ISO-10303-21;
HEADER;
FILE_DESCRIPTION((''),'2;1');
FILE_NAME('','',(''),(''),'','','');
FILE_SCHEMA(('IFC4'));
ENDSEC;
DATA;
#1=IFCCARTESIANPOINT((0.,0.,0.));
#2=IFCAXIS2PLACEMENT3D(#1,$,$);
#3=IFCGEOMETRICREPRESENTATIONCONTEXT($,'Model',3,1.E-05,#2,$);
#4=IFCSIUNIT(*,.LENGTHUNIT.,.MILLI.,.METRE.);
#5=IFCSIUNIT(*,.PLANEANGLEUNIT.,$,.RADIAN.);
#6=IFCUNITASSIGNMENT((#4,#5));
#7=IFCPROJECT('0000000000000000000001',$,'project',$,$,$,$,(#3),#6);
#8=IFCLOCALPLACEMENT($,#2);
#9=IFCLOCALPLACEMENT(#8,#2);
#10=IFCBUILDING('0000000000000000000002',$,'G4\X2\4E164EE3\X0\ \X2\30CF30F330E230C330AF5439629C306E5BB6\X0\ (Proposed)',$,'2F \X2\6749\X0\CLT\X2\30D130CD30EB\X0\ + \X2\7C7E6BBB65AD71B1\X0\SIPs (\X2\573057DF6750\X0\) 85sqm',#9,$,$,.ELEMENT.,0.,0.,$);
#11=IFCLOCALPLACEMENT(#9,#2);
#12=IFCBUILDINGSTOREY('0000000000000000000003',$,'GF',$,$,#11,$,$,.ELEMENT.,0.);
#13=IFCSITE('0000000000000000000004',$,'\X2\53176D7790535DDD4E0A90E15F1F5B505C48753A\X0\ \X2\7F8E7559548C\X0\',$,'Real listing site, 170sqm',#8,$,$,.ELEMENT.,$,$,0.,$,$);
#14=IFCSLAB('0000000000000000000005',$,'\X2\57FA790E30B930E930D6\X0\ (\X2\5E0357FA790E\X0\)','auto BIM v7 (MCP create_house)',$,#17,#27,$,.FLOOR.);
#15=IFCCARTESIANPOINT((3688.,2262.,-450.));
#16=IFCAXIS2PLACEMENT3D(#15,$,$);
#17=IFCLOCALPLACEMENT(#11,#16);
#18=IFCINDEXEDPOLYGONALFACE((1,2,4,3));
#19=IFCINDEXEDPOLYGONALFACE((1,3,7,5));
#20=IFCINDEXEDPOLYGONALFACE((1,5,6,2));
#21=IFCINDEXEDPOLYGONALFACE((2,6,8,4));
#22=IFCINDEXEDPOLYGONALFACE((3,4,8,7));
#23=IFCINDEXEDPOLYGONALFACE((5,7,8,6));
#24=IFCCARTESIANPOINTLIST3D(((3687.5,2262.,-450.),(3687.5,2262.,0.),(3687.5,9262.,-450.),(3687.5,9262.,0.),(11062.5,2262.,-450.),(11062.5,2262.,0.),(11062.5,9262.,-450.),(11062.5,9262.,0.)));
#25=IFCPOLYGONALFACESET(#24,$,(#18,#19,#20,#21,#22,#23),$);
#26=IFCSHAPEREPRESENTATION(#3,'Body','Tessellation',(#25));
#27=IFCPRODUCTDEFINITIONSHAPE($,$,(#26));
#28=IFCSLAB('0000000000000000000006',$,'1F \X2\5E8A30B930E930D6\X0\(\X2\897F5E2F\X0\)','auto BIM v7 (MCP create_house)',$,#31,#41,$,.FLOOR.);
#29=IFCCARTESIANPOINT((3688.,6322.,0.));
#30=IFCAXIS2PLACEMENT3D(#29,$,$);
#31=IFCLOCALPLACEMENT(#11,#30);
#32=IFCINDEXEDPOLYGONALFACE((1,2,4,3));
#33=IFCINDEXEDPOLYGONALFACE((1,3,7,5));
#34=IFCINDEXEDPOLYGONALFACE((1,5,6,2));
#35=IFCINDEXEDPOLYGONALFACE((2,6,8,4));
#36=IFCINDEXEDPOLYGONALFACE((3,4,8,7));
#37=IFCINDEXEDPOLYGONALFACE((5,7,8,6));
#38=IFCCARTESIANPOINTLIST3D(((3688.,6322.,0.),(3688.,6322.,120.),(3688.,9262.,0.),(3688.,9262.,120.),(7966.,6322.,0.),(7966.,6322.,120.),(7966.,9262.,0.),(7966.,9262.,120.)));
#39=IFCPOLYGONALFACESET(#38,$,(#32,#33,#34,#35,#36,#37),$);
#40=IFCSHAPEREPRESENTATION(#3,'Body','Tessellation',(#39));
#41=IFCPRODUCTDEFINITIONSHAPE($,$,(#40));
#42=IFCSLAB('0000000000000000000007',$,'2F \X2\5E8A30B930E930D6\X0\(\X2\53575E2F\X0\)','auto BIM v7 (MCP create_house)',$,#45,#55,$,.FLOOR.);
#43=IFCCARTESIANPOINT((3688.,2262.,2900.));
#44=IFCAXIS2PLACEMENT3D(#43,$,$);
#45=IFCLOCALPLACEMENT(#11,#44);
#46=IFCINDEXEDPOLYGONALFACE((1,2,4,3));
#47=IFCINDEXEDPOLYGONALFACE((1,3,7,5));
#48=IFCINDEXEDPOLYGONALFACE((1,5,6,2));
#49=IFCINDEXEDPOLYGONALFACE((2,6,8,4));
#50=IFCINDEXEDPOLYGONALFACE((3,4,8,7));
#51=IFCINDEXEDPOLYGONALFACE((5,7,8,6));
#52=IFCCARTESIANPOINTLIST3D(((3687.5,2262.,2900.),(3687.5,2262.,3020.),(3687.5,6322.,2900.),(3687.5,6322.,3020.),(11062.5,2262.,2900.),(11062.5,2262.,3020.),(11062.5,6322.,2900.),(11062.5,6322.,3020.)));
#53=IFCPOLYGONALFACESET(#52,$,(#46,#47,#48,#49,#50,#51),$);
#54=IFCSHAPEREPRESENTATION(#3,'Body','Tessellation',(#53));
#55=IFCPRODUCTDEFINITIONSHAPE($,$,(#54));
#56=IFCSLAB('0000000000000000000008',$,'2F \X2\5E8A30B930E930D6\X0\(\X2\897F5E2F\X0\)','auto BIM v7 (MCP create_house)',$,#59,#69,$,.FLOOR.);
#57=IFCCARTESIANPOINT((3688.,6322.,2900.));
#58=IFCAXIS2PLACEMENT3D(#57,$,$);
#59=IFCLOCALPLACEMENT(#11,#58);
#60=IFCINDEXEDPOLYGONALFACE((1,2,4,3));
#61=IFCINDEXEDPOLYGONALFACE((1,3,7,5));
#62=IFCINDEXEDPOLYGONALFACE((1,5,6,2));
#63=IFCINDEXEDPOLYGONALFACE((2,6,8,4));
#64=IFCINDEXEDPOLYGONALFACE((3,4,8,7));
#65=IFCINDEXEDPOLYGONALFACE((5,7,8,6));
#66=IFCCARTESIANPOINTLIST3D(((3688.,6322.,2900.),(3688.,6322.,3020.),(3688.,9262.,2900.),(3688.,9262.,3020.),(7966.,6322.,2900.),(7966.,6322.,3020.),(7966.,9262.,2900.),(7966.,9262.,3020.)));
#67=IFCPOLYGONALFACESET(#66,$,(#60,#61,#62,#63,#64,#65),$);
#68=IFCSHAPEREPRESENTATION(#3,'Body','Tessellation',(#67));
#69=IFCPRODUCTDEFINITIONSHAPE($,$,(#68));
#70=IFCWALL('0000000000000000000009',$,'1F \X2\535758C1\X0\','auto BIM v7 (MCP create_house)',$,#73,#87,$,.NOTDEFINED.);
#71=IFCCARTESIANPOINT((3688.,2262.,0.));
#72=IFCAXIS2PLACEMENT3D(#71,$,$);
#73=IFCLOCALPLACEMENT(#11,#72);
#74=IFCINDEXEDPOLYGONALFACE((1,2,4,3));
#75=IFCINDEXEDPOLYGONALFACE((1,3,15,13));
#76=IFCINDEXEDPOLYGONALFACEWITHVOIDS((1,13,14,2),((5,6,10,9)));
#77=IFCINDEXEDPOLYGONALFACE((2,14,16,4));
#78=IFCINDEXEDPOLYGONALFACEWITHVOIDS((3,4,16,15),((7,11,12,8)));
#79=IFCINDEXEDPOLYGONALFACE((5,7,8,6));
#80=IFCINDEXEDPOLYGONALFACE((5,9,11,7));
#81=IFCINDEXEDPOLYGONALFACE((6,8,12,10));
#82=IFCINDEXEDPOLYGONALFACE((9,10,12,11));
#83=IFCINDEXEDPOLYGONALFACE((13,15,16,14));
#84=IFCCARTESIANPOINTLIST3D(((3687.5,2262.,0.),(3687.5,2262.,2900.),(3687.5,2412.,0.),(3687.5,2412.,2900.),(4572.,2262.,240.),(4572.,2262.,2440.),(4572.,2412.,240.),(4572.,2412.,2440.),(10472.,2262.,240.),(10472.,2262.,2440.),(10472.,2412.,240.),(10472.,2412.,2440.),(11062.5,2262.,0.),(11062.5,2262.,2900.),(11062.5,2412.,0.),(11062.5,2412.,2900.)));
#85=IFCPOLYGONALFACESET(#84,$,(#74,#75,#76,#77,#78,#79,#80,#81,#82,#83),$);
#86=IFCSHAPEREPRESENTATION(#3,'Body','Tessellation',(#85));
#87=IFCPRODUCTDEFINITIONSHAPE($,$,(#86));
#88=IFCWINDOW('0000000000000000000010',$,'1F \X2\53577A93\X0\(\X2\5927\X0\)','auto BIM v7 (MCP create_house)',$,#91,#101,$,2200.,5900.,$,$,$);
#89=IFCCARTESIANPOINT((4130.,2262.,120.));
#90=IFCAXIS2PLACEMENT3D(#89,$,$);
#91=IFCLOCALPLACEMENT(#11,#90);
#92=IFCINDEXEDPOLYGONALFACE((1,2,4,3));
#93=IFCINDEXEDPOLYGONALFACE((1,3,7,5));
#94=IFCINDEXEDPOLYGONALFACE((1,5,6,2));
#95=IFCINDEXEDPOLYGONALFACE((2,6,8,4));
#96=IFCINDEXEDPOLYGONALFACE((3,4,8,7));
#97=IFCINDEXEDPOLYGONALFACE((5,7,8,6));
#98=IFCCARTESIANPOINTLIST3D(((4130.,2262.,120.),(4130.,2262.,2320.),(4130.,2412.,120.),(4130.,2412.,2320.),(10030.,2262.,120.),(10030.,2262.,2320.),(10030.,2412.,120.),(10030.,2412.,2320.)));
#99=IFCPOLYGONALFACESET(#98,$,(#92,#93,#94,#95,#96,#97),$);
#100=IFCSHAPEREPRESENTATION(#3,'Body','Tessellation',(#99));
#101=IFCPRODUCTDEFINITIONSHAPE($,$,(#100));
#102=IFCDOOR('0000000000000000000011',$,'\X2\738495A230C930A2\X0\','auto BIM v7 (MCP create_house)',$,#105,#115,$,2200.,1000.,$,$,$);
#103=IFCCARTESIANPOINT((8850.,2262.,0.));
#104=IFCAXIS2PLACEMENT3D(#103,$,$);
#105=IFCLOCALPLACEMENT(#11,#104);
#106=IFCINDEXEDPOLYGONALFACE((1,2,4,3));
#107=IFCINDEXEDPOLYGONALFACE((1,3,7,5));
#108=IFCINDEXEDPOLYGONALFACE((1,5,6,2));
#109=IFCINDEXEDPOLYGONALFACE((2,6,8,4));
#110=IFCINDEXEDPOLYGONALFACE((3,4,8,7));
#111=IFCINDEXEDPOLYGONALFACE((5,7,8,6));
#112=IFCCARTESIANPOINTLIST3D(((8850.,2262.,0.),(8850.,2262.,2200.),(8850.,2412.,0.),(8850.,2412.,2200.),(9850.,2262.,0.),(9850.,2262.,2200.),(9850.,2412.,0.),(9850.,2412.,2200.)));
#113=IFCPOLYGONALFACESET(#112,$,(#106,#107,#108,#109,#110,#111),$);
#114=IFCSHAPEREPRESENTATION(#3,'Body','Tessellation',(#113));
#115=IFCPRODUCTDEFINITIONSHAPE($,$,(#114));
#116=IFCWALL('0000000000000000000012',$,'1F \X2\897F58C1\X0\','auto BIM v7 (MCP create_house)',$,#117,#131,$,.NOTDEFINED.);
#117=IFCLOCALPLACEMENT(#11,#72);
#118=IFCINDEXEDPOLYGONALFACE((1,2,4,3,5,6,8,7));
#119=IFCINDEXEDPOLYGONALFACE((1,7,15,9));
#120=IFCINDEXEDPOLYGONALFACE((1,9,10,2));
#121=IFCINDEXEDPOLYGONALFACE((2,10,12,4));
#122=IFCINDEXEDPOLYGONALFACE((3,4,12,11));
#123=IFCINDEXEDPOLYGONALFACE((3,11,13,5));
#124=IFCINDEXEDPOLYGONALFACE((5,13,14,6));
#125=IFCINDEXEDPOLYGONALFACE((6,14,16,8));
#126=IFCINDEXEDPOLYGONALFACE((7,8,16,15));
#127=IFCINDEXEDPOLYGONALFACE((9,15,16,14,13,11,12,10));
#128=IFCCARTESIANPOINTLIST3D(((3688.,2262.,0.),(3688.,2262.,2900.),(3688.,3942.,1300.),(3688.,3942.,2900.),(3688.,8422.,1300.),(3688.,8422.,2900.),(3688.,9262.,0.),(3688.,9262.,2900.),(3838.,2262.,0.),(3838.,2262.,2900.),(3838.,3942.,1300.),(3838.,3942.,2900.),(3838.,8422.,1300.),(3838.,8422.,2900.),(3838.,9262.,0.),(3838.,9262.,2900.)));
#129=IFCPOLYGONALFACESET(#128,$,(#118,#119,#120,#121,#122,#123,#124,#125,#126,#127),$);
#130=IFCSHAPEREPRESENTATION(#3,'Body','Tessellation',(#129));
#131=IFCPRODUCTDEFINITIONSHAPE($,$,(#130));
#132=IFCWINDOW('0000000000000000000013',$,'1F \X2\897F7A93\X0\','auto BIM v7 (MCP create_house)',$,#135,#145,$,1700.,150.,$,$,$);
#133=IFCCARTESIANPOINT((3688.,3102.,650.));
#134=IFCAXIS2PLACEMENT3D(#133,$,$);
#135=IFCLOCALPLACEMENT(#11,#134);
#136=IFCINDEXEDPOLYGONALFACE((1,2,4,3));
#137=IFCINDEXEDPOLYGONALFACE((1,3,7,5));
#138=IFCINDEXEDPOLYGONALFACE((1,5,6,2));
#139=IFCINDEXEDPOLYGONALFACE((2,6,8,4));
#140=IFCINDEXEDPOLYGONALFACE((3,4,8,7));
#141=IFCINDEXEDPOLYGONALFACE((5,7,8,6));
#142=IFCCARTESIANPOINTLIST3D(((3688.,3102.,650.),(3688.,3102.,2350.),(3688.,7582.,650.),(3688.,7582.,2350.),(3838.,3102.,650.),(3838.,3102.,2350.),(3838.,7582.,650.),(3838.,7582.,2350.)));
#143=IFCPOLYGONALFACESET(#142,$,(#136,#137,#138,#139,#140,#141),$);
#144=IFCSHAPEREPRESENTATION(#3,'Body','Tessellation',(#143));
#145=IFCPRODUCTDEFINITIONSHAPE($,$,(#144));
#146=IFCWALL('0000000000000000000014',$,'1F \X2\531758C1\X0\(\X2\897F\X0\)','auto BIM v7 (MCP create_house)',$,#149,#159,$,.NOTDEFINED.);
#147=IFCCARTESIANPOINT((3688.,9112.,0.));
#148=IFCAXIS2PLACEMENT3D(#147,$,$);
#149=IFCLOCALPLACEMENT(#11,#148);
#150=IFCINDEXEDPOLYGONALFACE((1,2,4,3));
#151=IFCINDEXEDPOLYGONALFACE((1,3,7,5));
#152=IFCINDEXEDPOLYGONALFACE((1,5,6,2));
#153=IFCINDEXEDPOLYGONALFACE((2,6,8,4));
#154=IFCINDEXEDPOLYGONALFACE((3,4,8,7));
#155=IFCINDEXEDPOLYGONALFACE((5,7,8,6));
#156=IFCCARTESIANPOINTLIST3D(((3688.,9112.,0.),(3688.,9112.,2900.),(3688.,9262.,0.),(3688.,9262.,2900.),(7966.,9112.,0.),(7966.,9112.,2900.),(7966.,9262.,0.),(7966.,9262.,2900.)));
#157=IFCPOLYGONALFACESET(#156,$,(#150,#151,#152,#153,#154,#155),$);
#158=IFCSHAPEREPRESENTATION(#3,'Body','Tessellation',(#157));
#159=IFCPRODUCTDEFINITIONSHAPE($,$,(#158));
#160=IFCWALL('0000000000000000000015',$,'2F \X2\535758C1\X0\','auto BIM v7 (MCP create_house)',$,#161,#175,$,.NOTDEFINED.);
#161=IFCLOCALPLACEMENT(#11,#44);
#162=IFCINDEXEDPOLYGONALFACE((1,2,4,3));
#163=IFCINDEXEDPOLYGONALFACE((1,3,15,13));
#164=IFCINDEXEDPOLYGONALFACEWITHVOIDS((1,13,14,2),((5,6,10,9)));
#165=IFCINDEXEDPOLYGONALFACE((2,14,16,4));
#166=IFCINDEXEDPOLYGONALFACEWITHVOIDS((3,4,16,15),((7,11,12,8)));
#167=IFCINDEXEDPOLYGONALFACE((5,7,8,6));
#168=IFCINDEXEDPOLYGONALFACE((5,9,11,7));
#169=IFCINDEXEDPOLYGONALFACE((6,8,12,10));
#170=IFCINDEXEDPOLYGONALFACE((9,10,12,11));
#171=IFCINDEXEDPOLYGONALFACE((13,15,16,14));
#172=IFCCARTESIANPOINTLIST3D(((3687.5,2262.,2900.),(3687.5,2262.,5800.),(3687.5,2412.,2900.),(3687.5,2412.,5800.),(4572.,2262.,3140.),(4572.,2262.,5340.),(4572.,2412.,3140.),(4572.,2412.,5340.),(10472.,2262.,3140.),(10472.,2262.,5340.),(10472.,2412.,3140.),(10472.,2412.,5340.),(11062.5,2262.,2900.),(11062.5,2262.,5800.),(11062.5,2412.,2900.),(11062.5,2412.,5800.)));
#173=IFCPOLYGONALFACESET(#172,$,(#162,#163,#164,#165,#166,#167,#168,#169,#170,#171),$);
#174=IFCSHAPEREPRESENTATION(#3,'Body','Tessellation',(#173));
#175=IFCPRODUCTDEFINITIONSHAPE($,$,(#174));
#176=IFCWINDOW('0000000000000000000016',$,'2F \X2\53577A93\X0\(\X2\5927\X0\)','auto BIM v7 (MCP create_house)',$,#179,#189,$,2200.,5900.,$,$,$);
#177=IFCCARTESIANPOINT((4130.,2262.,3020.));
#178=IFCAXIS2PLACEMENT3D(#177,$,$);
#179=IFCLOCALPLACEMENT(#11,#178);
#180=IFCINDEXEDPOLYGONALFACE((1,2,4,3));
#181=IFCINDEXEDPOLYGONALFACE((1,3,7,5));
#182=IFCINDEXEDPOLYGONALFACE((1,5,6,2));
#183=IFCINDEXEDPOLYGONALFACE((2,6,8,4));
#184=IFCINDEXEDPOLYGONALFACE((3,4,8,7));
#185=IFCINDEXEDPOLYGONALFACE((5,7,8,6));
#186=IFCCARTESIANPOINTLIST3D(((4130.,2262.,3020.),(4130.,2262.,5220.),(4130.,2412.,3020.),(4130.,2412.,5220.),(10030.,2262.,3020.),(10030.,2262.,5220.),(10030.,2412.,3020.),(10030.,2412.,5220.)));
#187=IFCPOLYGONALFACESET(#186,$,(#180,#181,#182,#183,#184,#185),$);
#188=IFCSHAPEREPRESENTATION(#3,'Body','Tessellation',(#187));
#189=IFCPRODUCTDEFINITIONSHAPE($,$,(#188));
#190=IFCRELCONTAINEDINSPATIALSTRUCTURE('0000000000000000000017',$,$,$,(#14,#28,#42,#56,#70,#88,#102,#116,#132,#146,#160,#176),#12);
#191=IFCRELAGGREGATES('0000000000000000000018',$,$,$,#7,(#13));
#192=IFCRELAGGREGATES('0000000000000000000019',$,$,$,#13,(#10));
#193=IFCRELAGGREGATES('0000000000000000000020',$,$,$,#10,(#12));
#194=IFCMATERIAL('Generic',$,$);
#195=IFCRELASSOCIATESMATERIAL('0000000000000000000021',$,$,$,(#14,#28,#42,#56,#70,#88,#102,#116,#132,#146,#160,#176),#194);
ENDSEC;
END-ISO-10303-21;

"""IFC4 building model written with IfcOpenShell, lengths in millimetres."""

from ifc_helpers import new_model, si_unit, frame, frame_2d, origin, place, context, project, spatial, rectangle, extrude, material, element, fill, save


model = new_model("IFC4")

# Units and contexts
model_context = context("Model", 3, precision=1e-05, world=origin())
ifc_project = project(units=[si_unit("LENGTHUNIT", "METRE", prefix="MILLI"), si_unit("PLANEANGLEUNIT", "RADIAN")], contexts=[model_context])

# Site, building, storey
site_placement = place(None, origin())
site = spatial("IfcSite", under=ifc_project, at=site_placement, Name="北海道川上郡弟子屈町 美留和", ObjectType="Real listing site, 170sqm", CompositionType="ELEMENT", RefElevation=0.0)
building_placement = place(site_placement, origin())
building = spatial("IfcBuilding", under=site, at=building_placement, Name="G4世代 ハンモック吹抜の家 (Proposed)", ObjectType="2F 杉CLTパネル + 籾殻断熱SIPs (地域材) 85sqm", CompositionType="ELEMENT", ElevationOfRefHeight=0.0, ElevationOfTerrain=0.0)
storey_placement = place(building_placement, origin())
storey = spatial("IfcBuildingStorey", under=building, at=storey_placement, Name="GF", CompositionType="ELEMENT", Elevation=0.0)

# Slabs
ifc_material = material(Name="Generic")
slab_1_placement = place(storey_placement, frame((3688.0, 2262.0, -450.0)))
element("IfcSlab", 1, at=slab_1_placement, inside=storey, material=ifc_material, Name="基礎スラブ (布基礎)", Description="auto BIM v7 (MCP create_house)", PredefinedType="FLOOR", context=model_context, shape_type="SweptSolid", body=[
    extrude(rectangle(XDim=7375.0, YDim=7000.0, at=frame_2d((3687.0, 3500.0))), frame((3688.0, 2262.0, -450.0)), (0.0, 0.0, 1.0), 450.0),
])
slab_2_placement = place(storey_placement, frame((3688.0, 6322.0, 0.0)))
element("IfcSlab", 2, at=slab_2_placement, inside=storey, material=ifc_material, Name="1F 床スラブ(西帯)", Description="auto BIM v7 (MCP create_house)", PredefinedType="FLOOR", context=model_context, shape_type="SweptSolid", body=[
    extrude(rectangle(XDim=4278.0, YDim=2940.0, at=frame_2d((2139.0, 1470.0))), frame((3688.0, 6322.0, 0.0)), (0.0, 0.0, 1.0), 120.0),
])
slab_3_placement = place(storey_placement, frame((3688.0, 2262.0, 2900.0)))
element("IfcSlab", 3, at=slab_3_placement, inside=storey, material=ifc_material, Name="2F 床スラブ(南帯)", Description="auto BIM v7 (MCP create_house)", PredefinedType="FLOOR", context=model_context, shape_type="SweptSolid", body=[
    extrude(rectangle(XDim=7375.0, YDim=4060.0, at=frame_2d((3687.0, 2030.0))), frame((3688.0, 2262.0, 2900.0)), (0.0, 0.0, 1.0), 120.0),
])
slab_4_placement = place(storey_placement, frame((3688.0, 6322.0, 2900.0)))
element("IfcSlab", 4, at=slab_4_placement, inside=storey, material=ifc_material, Name="2F 床スラブ(西帯)", Description="auto BIM v7 (MCP create_house)", PredefinedType="FLOOR", context=model_context, shape_type="SweptSolid", body=[
    extrude(rectangle(XDim=4278.0, YDim=2940.0, at=frame_2d((2139.0, 1470.0))), frame((3688.0, 6322.0, 2900.0)), (0.0, 0.0, 1.0), 120.0),
])

# Wall, openings, window, door
wall_1_placement = place(storey_placement, frame((3688.0, 2262.0, 0.0)))
wall_1 = element("IfcWall", 5, at=wall_1_placement, inside=storey, material=ifc_material, Name="1F 南壁", Description="auto BIM v7 (MCP create_house)", PredefinedType="NOTDEFINED", context=model_context, shape_type="SweptSolid", body=[
    extrude(rectangle(XDim=7375.0, YDim=150.0, at=frame_2d((3687.0, 75.0))), frame((3688.0, 2262.0, 0.0)), (0.0, 0.0, 1.0), 2900.0),
])
opening_1_placement = place(storey_placement, frame((4130.0, 2262.0, 120.0)))
opening_1 = element("IfcOpeningElement", 6, at=opening_1_placement, cuts=wall_1, PredefinedType="NOTDEFINED", context=model_context, shape_type="SweptSolid", body=[
    extrude(rectangle(XDim=5900.0, YDim=150.0, at=frame_2d((2950.0, 75.0))), frame((4130.0, 2262.0, 120.0)), (0.0, 0.0, 1.0), 2200.0),
])
opening_2_placement = place(storey_placement, frame((8850.0, 2262.0, 0.0)))
opening_2 = element("IfcOpeningElement", 7, at=opening_2_placement, cuts=wall_1, PredefinedType="NOTDEFINED", context=model_context, shape_type="SweptSolid", body=[
    extrude(rectangle(XDim=1000.0, YDim=150.0, at=frame_2d((500.0, 75.0))), frame((8850.0, 2262.0, 0.0)), (0.0, 0.0, 1.0), 2200.0),
])
window_1_placement = place(storey_placement, frame((4130.0, 2262.0, 120.0)))
window_1 = element("IfcWindow", 8, at=window_1_placement, inside=storey, material=ifc_material, Name="1F 南窓(大)", Description="auto BIM v7 (MCP create_house)", OverallHeight=2200.0, OverallWidth=5900.0, context=model_context, shape_type="SweptSolid", body=[
    extrude(rectangle(XDim=5900.0, YDim=150.0, at=frame_2d((2950.0, 75.0))), frame((4130.0, 2262.0, 120.0)), (0.0, 0.0, 1.0), 2200.0),
])
fill(opening_1, window_1)
door_placement = place(storey_placement, frame((8850.0, 2262.0, 0.0)))
door = element("IfcDoor", 9, at=door_placement, inside=storey, material=ifc_material, Name="玄関ドア", Description="auto BIM v7 (MCP create_house)", OverallHeight=2200.0, OverallWidth=1000.0, context=model_context, shape_type="SweptSolid", body=[
    extrude(rectangle(XDim=1000.0, YDim=150.0, at=frame_2d((500.0, 75.0))), frame((8850.0, 2262.0, 0.0)), (0.0, 0.0, 1.0), 2200.0),
])
fill(opening_2, door)

# Wall, opening, window
wall_2_placement = place(storey_placement, frame((3688.0, 2262.0, 0.0)))
wall_2 = element("IfcWall", 10, at=wall_2_placement, inside=storey, material=ifc_material, Name="1F 西壁", Description="auto BIM v7 (MCP create_house)", PredefinedType="NOTDEFINED", context=model_context, shape_type="SweptSolid", body=[
    extrude(rectangle(XDim=150.0, YDim=7000.0, at=frame_2d((75.0, 3500.0))), frame((3688.0, 2262.0, 0.0)), (0.0, 0.0, 1.0), 2900.0),
])
opening_3_placement = place(storey_placement, frame((3688.0, 3102.0, 650.0)))
opening_3 = element("IfcOpeningElement", 11, at=opening_3_placement, cuts=wall_2, PredefinedType="NOTDEFINED", context=model_context, shape_type="SweptSolid", body=[
    extrude(rectangle(XDim=150.0, YDim=4480.0, at=frame_2d((75.0, 2240.0))), frame((3688.0, 3102.0, 650.0)), (0.0, 0.0, 1.0), 1700.0),
])
window_2_placement = place(storey_placement, frame((3688.0, 3102.0, 650.0)))
window_2 = element("IfcWindow", 12, at=window_2_placement, inside=storey, material=ifc_material, Name="1F 西窓", Description="auto BIM v7 (MCP create_house)", OverallHeight=1700.0, OverallWidth=150.0, context=model_context, shape_type="SweptSolid", body=[
    extrude(rectangle(XDim=150.0, YDim=4480.0, at=frame_2d((75.0, 2240.0))), frame((3688.0, 3102.0, 650.0)), (0.0, 0.0, 1.0), 1700.0),
])
fill(opening_3, window_2)

# Wall
wall_3_placement = place(storey_placement, frame((3688.0, 9112.0, 0.0)))
element("IfcWall", 13, at=wall_3_placement, inside=storey, material=ifc_material, Name="1F 北壁(西)", Description="auto BIM v7 (MCP create_house)", PredefinedType="NOTDEFINED", context=model_context, shape_type="SweptSolid", body=[
    extrude(rectangle(XDim=4278.0, YDim=150.0, at=frame_2d((2139.0, 75.0))), frame((3688.0, 9112.0, 0.0)), (0.0, 0.0, 1.0), 2900.0),
])

# Wall, opening, window
wall_4_placement = place(storey_placement, frame((3688.0, 2262.0, 2900.0)))
wall_4 = element("IfcWall", 14, at=wall_4_placement, inside=storey, material=ifc_material, Name="2F 南壁", Description="auto BIM v7 (MCP create_house)", PredefinedType="NOTDEFINED", context=model_context, shape_type="SweptSolid", body=[
    extrude(rectangle(XDim=7375.0, YDim=150.0, at=frame_2d((3687.0, 75.0))), frame((3688.0, 2262.0, 2900.0)), (0.0, 0.0, 1.0), 2900.0),
])
opening_4_placement = place(storey_placement, frame((4130.0, 2262.0, 3020.0)))
opening_4 = element("IfcOpeningElement", 15, at=opening_4_placement, cuts=wall_4, PredefinedType="NOTDEFINED", context=model_context, shape_type="SweptSolid", body=[
    extrude(rectangle(XDim=5900.0, YDim=150.0, at=frame_2d((2950.0, 75.0))), frame((4130.0, 2262.0, 3020.0)), (0.0, 0.0, 1.0), 2200.0),
])
window_3_placement = place(storey_placement, frame((4130.0, 2262.0, 3020.0)))
window_3 = element("IfcWindow", 16, at=window_3_placement, inside=storey, material=ifc_material, Name="2F 南窓(大)", Description="auto BIM v7 (MCP create_house)", OverallHeight=2200.0, OverallWidth=5900.0, context=model_context, shape_type="SweptSolid", body=[
    extrude(rectangle(XDim=5900.0, YDim=150.0, at=frame_2d((2950.0, 75.0))), frame((4130.0, 2262.0, 3020.0)), (0.0, 0.0, 1.0), 2200.0),
])
fill(opening_4, window_3)

save(model, "model.ifc")
